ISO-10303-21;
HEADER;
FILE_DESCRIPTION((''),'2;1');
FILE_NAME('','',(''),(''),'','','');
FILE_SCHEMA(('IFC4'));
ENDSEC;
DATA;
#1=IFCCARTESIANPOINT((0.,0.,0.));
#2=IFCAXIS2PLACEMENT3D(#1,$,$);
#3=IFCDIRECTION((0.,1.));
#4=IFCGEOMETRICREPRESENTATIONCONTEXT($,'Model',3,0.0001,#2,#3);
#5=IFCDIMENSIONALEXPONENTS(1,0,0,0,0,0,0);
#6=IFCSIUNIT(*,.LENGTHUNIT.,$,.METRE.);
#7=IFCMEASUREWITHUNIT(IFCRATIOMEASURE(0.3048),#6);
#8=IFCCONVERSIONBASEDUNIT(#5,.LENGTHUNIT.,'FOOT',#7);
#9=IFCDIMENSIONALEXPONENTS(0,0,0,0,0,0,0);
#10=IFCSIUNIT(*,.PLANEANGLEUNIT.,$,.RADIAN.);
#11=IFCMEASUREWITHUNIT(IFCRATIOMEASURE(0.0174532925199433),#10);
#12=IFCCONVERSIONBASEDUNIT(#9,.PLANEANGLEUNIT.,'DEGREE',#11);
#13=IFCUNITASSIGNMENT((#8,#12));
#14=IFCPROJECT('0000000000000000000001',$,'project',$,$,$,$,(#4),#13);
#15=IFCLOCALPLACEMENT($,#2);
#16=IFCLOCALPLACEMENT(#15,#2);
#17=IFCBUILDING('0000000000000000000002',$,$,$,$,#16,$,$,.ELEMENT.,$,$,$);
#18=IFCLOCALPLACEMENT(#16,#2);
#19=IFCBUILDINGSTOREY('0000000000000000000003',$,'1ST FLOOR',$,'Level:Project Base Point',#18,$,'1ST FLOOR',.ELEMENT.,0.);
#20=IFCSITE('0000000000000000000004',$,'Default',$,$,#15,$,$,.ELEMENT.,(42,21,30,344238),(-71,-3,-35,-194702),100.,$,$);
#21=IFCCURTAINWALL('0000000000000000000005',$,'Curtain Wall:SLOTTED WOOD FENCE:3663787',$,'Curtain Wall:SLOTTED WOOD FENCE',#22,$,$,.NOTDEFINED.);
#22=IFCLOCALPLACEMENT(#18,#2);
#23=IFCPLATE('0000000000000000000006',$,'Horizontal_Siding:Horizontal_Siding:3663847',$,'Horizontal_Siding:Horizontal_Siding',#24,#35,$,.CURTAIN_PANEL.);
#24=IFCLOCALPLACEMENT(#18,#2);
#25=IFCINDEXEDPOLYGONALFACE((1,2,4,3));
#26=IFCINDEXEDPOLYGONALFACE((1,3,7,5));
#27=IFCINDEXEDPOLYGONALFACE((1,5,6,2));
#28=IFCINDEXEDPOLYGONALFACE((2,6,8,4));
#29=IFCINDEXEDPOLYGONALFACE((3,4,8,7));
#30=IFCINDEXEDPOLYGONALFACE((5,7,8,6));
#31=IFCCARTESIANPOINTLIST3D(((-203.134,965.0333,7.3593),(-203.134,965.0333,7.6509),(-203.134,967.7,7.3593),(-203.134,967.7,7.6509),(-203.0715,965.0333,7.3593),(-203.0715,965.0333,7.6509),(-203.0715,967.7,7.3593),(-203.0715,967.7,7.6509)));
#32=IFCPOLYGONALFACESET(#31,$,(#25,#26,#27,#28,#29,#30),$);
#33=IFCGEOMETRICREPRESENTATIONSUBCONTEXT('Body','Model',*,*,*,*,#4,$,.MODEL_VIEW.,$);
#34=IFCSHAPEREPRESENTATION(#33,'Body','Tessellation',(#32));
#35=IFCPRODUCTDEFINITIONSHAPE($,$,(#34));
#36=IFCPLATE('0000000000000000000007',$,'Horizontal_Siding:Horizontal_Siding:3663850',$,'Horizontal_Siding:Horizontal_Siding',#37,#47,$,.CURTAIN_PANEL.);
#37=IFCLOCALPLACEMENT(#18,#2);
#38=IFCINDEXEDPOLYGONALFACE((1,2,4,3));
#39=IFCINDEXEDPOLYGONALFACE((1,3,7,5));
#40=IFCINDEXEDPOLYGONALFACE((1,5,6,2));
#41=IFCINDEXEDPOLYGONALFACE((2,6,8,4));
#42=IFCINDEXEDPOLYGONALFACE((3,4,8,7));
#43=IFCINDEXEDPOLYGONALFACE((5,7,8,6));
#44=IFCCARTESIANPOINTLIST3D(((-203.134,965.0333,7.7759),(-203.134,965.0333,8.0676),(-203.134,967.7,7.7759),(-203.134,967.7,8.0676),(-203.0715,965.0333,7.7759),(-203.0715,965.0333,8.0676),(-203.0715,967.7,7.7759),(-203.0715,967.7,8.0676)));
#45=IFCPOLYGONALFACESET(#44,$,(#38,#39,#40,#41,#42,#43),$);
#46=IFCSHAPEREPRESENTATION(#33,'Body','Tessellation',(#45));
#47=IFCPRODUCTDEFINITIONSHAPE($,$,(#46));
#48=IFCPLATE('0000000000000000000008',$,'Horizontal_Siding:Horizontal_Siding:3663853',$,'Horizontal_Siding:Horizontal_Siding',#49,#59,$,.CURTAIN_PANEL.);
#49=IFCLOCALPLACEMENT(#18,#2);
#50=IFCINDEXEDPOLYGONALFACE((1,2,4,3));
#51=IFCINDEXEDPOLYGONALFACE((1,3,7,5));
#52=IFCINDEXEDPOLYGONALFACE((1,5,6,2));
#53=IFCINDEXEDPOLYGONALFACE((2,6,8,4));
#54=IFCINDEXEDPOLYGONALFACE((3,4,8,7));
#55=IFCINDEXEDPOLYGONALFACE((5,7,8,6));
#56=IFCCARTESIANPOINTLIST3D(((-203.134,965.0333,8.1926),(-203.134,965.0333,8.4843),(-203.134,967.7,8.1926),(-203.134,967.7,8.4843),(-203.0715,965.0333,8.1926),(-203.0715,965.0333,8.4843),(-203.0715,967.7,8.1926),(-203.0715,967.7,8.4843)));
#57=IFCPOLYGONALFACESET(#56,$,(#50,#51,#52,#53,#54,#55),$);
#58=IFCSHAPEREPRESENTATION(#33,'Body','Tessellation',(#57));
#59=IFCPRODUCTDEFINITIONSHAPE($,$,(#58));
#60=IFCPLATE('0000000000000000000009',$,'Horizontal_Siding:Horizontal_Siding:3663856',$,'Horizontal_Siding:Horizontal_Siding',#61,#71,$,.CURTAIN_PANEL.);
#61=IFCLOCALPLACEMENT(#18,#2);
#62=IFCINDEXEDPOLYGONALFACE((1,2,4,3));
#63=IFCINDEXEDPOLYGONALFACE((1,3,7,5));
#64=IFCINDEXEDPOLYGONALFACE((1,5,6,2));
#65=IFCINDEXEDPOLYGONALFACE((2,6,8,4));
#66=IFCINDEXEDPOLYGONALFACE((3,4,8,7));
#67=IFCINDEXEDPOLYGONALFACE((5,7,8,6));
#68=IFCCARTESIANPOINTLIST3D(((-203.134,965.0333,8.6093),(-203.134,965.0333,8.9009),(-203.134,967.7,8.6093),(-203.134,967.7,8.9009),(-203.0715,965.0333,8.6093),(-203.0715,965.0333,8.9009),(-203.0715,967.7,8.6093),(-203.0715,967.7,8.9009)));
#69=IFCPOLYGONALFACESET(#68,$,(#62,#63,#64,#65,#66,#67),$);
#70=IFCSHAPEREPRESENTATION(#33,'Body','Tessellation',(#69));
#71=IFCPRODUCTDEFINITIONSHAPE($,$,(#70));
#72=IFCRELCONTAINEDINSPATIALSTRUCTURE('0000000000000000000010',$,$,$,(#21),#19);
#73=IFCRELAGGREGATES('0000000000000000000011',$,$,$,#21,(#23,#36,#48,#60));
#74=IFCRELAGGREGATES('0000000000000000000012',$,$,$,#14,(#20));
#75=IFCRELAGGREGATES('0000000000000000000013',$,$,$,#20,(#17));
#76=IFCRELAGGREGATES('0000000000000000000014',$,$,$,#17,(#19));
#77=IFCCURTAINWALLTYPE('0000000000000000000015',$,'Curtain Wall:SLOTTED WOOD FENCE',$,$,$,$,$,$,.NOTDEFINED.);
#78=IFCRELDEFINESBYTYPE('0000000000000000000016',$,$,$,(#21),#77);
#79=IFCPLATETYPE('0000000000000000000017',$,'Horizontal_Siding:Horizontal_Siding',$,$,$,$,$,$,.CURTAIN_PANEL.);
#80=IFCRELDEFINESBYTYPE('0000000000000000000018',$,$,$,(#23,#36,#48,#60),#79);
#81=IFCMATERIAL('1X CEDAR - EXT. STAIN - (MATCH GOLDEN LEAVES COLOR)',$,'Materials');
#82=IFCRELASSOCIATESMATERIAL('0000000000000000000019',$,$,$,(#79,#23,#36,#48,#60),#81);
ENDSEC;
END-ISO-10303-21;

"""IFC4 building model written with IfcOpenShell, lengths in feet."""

from ifc_helpers import new_model, entity, si_unit, converted_unit, direction, frame, origin, origin_2d_with_axis, place, context, subcontext, project, spatial, rectangle, extrude, source, transform, mapped, material, type_object, type_shapes, element, aggregate, save


model = new_model("IFC4")

# Units and contexts
model_context = context("Model", 3, precision=0.0001, world=origin(), true_north=direction((0.0, 1.0)))
body_context = subcontext(model_context, "Body", "Model", "MODEL_VIEW")
ifc_project = project(units=[converted_unit("LENGTHUNIT", "FOOT", entity("IfcRatioMeasure", 0.3048), si_unit("LENGTHUNIT", "METRE"), dimensions=[1, 0, 0, 0, 0, 0, 0]), converted_unit("PLANEANGLEUNIT", "DEGREE", entity("IfcRatioMeasure", 0.0174532925199433), si_unit("PLANEANGLEUNIT", "RADIAN"), dimensions=[0, 0, 0, 0, 0, 0, 0])], contexts=[model_context])

# Site, building, storey
site_placement = place(None, origin())
site = spatial("IfcSite", under=ifc_project, at=site_placement, Name="Default", CompositionType="ELEMENT", RefLatitude=(42, 21, 30, 344238), RefLongitude=(-71, -3, -35, -194702), RefElevation=100.0)
building_placement = place(site_placement, origin())
building = spatial("IfcBuilding", under=site, at=building_placement, CompositionType="ELEMENT")
storey_placement = place(building_placement, origin())
storey = spatial("IfcBuildingStorey", under=building, at=storey_placement, Name="1ST FLOOR", ObjectType="Level:Project Base Point", LongName="1ST FLOOR", CompositionType="ELEMENT", Elevation=0.0)

# Curtain wall, plates
curtain_wall_type = type_object("IfcCurtainWallType", Name="Curtain Wall:SLOTTED WOOD FENCE", PredefinedType="NOTDEFINED")
curtain_wall_placement = place(storey_placement, origin())
curtain_wall = element("IfcCurtainWall", 1, at=curtain_wall_placement, inside=storey, type_object=curtain_wall_type, Name="Curtain Wall:SLOTTED WOOD FENCE:3663787", ObjectType="Curtain Wall:SLOTTED WOOD FENCE", PredefinedType="NOTDEFINED")
ifc_material_1 = material(Name="1X CEDAR - EXT. STAIN - (MATCH GOLDEN LEAVES COLOR)", Category="Materials")
plate_type = type_object("IfcPlateType", Name="Horizontal_Siding:Horizontal_Siding", PredefinedType="CURTAIN_PANEL", material=ifc_material_1)
shared_shape_1 = source(origin(), body_context, "Body", "SweptSolid", [
    extrude(rectangle(XDim=2.6667, YDim=0.0625, at=origin_2d_with_axis()), frame((1.3333, 0.0312, 0.0), z_axis=(0.0, 0.0, 1.0), x_axis=(-1.0, 0.0, 0.0)), (0.0, 0.0, 1.0), 0.2917),
])
type_shapes(plate_type, [shared_shape_1])
plate_1_placement = place(curtain_wall_placement, frame((-203.134, 967.7, 7.3593), z_axis=(0.0, 0.0, 1.0), x_axis=(0.0, -1.0, 0.0)))
plate_1 = element("IfcPlate", 2, at=plate_1_placement, type_object=plate_type, material=ifc_material_1, Name="Horizontal_Siding:Horizontal_Siding:3663847", ObjectType="Horizontal_Siding:Horizontal_Siding", PredefinedType="CURTAIN_PANEL", context=body_context, shape_type="MappedRepresentation", body=[
    mapped(shared_shape_1, transform((0.0, 0.0, 0.0), scale=1.0)),
])
plate_2_placement = place(curtain_wall_placement, frame((-203.134, 967.7, 7.7759), z_axis=(0.0, 0.0, 1.0), x_axis=(0.0, -1.0, 0.0)))
plate_2 = element("IfcPlate", 3, at=plate_2_placement, type_object=plate_type, material=ifc_material_1, Name="Horizontal_Siding:Horizontal_Siding:3663850", ObjectType="Horizontal_Siding:Horizontal_Siding", PredefinedType="CURTAIN_PANEL", context=body_context, shape_type="MappedRepresentation", body=[
    mapped(shared_shape_1, transform((0.0, 0.0, 0.0), scale=1.0)),
])
plate_3_placement = place(curtain_wall_placement, frame((-203.134, 967.7, 8.1926), z_axis=(0.0, 0.0, 1.0), x_axis=(0.0, -1.0, 0.0)))
plate_3 = element("IfcPlate", 4, at=plate_3_placement, type_object=plate_type, material=ifc_material_1, Name="Horizontal_Siding:Horizontal_Siding:3663853", ObjectType="Horizontal_Siding:Horizontal_Siding", PredefinedType="CURTAIN_PANEL", context=body_context, shape_type="MappedRepresentation", body=[
    mapped(shared_shape_1, transform((0.0, 0.0, 0.0), scale=1.0)),
])
plate_4_placement = place(curtain_wall_placement, frame((-203.134, 967.7, 8.6093), z_axis=(0.0, 0.0, 1.0), x_axis=(0.0, -1.0, 0.0)))
plate_4 = element("IfcPlate", 5, at=plate_4_placement, type_object=plate_type, material=ifc_material_1, Name="Horizontal_Siding:Horizontal_Siding:3663856", ObjectType="Horizontal_Siding:Horizontal_Siding", PredefinedType="CURTAIN_PANEL", context=body_context, shape_type="MappedRepresentation", body=[
    mapped(shared_shape_1, transform((0.0, 0.0, 0.0), scale=1.0)),
])
aggregate(curtain_wall, [plate_1, plate_2, plate_3, plate_4])

save(model, "model.ifc")
